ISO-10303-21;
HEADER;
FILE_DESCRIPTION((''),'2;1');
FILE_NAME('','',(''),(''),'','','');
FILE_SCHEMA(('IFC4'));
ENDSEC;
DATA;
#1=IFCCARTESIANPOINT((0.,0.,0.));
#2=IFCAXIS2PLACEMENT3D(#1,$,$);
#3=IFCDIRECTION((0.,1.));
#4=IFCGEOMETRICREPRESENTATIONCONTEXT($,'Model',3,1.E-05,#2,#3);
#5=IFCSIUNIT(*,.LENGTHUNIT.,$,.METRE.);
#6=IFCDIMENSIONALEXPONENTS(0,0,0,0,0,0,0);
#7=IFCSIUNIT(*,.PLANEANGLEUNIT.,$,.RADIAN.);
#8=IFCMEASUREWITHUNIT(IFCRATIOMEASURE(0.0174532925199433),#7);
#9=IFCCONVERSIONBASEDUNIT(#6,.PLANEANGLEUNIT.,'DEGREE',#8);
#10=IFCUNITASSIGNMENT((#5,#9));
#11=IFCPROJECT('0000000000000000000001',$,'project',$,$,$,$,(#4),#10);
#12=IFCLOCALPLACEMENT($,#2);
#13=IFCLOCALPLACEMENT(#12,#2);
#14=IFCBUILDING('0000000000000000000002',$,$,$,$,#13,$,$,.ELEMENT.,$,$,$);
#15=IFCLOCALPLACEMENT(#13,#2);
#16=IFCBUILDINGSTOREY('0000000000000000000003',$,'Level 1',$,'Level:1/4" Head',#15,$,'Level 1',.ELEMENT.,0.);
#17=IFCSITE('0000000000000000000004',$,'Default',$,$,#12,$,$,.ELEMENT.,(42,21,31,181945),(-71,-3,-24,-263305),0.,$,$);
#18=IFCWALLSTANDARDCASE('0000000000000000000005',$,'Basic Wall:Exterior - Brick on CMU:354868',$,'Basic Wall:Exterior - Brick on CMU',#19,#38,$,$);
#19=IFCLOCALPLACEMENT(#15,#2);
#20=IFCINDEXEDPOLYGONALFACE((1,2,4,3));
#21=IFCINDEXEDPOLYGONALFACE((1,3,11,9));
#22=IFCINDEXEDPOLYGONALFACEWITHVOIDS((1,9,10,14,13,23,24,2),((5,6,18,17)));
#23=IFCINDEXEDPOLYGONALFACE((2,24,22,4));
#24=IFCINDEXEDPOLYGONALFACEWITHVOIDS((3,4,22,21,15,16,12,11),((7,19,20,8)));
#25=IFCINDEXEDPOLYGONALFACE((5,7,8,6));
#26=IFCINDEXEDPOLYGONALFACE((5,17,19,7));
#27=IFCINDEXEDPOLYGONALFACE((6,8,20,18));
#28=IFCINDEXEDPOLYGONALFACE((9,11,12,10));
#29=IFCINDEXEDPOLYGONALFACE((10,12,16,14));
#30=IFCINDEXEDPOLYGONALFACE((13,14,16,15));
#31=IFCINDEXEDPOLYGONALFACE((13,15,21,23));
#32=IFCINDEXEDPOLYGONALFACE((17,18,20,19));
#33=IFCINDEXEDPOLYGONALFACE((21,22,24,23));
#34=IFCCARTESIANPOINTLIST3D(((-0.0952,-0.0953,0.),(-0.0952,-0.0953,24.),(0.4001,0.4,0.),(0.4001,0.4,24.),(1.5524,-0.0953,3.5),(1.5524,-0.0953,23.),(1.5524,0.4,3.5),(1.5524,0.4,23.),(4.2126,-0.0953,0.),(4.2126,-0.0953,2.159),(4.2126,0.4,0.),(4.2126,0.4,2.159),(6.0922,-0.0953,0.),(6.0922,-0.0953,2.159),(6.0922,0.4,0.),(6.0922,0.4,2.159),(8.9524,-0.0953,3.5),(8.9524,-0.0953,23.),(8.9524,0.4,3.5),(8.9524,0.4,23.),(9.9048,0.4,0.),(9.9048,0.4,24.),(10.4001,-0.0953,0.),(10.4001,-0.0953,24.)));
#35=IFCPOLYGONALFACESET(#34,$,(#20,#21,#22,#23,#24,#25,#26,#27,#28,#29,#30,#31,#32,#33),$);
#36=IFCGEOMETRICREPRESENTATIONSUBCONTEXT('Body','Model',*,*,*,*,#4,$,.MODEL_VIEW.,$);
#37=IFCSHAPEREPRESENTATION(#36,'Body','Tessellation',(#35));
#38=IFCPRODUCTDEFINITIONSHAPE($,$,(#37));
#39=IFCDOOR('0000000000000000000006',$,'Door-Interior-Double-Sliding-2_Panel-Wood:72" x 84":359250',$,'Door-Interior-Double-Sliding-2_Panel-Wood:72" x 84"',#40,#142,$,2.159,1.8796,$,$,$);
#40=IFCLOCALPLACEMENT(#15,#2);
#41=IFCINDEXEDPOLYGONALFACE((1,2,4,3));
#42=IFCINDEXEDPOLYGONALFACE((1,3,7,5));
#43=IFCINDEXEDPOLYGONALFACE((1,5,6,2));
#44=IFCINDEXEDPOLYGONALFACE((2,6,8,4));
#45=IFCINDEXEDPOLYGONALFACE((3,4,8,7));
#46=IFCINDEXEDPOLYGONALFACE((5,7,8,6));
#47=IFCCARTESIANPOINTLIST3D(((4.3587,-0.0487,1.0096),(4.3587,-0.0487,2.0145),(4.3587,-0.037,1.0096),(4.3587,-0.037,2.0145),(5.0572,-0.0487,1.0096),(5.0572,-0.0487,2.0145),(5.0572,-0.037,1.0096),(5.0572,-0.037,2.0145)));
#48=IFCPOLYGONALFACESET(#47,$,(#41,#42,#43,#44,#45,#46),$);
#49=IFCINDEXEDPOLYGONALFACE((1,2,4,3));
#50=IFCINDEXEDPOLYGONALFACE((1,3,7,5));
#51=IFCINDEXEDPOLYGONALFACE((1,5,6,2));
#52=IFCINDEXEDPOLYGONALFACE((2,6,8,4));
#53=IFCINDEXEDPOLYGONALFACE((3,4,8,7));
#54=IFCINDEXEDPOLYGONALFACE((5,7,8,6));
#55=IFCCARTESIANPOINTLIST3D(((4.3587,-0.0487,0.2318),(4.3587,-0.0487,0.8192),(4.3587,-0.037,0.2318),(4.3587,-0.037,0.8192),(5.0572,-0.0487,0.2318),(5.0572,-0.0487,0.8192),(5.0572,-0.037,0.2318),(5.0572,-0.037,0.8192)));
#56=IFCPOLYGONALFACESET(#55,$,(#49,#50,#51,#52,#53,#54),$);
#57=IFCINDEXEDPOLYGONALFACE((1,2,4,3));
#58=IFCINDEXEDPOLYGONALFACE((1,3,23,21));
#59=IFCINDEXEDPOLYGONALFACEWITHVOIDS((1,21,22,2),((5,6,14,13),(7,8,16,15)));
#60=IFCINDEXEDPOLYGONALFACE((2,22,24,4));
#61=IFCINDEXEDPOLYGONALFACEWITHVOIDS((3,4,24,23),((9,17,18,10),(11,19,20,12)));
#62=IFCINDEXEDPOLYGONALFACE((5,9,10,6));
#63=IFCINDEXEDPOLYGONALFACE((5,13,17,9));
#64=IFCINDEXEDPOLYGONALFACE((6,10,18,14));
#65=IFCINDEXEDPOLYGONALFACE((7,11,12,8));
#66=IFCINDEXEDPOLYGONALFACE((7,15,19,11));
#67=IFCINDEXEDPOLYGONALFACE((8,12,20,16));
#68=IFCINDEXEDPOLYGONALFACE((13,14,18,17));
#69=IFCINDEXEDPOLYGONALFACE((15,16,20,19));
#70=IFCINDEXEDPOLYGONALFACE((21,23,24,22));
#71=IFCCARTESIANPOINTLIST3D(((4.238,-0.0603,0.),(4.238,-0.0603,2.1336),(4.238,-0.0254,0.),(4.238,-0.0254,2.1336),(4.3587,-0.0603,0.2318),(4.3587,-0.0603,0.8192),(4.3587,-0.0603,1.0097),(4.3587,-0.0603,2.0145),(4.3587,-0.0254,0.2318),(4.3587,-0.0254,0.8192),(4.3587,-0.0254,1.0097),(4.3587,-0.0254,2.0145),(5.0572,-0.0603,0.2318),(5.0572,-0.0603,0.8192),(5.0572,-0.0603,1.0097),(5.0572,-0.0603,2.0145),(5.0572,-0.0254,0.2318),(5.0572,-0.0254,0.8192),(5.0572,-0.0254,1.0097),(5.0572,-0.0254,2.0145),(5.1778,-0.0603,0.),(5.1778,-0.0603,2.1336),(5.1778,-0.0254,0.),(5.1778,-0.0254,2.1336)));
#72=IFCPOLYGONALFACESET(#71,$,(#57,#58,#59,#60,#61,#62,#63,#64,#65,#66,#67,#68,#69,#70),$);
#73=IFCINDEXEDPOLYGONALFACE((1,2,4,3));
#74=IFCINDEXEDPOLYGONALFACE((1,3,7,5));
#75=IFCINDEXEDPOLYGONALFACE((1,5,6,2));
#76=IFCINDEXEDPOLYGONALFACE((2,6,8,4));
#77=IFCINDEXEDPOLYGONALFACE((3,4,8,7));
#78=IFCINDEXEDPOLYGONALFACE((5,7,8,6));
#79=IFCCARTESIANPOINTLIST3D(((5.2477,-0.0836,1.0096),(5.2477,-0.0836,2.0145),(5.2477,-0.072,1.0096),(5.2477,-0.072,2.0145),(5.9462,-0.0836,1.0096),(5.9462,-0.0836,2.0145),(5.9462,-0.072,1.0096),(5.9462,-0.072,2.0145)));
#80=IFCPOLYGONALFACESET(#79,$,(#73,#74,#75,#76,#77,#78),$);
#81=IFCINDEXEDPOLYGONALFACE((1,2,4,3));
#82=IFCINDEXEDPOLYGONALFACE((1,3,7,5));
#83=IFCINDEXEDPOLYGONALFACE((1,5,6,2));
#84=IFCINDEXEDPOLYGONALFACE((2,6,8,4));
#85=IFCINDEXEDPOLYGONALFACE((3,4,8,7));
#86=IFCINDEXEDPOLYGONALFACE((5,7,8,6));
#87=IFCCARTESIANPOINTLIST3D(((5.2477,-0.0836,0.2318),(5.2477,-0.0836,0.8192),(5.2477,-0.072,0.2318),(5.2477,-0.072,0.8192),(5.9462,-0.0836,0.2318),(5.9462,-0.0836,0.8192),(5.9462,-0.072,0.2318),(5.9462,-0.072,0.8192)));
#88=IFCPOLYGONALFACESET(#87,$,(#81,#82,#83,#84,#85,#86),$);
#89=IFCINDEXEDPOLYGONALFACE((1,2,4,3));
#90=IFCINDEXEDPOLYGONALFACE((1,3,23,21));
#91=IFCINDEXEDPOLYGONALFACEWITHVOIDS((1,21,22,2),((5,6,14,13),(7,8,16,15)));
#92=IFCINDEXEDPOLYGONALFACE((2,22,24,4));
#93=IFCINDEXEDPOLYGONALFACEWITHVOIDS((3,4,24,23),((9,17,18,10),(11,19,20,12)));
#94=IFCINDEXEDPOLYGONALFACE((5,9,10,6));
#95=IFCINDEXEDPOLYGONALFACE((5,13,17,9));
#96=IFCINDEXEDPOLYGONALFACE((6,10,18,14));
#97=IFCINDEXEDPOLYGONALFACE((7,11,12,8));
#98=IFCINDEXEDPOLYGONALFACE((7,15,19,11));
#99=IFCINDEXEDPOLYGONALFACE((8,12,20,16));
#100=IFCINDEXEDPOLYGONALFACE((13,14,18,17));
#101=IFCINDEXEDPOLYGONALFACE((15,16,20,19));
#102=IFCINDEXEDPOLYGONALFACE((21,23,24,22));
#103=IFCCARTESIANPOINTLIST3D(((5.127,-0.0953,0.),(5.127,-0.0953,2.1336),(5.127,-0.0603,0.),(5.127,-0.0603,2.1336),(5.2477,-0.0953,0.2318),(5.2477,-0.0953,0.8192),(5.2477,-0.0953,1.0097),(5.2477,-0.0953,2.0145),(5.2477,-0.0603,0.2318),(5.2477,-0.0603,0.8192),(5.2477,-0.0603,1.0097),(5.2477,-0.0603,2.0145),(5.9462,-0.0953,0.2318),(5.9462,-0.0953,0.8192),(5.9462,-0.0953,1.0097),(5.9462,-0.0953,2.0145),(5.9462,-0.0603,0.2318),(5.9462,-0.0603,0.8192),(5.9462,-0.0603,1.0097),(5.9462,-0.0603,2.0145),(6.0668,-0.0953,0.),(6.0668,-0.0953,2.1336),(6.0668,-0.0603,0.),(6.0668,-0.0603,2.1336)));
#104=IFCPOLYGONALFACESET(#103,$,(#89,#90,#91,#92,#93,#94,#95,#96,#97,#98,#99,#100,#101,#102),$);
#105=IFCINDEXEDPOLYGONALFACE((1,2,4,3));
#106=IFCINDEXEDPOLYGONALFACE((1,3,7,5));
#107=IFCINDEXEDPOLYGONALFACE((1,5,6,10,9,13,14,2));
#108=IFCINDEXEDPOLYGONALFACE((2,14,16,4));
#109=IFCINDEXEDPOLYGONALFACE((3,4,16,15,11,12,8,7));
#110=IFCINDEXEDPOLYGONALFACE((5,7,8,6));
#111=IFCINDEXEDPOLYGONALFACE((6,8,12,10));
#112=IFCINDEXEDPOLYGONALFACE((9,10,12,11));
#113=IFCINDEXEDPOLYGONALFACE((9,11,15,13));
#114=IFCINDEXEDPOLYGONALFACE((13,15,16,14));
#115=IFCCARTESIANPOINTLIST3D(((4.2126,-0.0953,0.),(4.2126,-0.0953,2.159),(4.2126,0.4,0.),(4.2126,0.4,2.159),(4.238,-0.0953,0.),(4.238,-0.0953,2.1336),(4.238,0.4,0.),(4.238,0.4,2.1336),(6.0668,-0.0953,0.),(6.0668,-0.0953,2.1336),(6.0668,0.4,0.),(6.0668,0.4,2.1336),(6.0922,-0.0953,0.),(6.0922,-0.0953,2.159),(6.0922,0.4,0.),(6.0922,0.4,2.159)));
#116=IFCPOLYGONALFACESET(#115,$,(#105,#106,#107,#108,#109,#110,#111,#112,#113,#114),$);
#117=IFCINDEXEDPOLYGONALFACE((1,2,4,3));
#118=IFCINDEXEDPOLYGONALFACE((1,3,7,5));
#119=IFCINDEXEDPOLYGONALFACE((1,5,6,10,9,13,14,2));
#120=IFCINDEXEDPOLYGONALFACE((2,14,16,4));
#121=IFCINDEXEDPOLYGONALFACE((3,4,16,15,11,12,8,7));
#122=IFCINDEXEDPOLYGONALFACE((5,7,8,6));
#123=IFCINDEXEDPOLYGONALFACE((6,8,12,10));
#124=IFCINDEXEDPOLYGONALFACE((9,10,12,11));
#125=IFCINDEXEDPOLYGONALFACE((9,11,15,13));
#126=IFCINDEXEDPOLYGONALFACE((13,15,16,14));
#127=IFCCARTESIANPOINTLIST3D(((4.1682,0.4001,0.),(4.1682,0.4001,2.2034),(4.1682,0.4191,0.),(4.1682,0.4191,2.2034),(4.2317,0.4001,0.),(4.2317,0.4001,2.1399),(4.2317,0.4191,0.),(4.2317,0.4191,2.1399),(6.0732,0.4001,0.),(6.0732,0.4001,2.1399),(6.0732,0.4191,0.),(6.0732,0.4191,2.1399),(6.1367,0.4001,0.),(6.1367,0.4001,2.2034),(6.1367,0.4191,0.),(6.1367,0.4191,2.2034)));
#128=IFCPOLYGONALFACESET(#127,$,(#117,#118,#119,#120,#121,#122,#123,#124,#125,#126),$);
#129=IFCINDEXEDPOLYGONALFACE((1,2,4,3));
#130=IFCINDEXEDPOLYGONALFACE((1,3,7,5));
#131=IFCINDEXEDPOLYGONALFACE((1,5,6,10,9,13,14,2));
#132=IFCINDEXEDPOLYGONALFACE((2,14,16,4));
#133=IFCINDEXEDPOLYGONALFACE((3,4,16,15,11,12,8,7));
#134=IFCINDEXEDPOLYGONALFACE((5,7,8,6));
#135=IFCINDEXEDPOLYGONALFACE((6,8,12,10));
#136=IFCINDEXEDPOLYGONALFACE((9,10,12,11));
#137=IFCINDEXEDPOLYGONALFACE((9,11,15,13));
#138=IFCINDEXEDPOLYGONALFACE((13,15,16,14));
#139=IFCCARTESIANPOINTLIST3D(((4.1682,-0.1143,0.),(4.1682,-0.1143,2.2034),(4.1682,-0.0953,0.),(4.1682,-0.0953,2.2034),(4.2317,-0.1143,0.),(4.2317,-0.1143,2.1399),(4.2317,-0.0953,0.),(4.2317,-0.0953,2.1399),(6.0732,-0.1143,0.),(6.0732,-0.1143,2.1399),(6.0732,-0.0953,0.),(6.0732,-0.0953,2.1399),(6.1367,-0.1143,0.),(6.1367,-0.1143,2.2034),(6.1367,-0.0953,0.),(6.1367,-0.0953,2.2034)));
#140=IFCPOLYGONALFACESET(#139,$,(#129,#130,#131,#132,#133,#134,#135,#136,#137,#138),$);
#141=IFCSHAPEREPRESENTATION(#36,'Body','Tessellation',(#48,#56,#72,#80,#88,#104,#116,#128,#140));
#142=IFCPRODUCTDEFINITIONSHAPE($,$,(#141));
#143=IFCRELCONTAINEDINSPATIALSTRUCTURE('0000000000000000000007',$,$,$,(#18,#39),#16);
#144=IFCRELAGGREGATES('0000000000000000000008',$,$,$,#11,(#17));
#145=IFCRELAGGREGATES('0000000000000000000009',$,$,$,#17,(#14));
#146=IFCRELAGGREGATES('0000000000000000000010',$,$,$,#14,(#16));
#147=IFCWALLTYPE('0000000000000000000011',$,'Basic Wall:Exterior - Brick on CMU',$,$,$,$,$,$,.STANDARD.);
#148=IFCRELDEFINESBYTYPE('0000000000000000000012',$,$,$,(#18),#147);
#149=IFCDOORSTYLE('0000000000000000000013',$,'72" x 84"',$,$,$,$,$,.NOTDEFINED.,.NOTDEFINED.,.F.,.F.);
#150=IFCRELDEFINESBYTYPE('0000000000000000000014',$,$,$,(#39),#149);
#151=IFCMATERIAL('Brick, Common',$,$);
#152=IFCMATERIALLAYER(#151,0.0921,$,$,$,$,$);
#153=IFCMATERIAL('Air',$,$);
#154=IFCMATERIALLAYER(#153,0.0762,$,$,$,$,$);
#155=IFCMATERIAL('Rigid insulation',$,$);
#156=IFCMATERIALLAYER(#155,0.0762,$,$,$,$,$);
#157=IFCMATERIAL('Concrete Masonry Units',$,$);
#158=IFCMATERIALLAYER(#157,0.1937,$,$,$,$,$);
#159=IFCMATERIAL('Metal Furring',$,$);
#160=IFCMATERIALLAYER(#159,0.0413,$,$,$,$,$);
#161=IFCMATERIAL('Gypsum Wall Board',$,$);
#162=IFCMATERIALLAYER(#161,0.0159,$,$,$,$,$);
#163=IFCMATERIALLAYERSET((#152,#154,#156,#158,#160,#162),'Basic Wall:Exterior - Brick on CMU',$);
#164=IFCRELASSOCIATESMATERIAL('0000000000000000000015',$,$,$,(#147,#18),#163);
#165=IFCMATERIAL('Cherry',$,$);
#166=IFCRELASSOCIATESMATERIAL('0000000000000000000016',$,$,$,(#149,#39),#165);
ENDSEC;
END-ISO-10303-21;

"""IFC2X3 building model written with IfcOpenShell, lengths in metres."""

from ifc_helpers import new_model, entity, si_unit, converted_unit, direction, frame, frame_2d, origin, origin_2d_with_axis, place, context, subcontext, project, spatial, polyline, rectangle, outline, extrude, source, transform, mapped, material, layer, layer_set, layer_usage, type_object, type_shapes, element, fill, save


model = new_model("IFC2X3")

# Units and contexts
model_context = context("Model", 3, precision=1e-05, world=origin(), true_north=direction((0.0, 1.0)))
body_context = subcontext(model_context, "Body", "Model", "MODEL_VIEW")
ifc_project = project(units=[si_unit("LENGTHUNIT", "METRE"), converted_unit("PLANEANGLEUNIT", "DEGREE", entity("IfcRatioMeasure", 0.0174532925199433), si_unit("PLANEANGLEUNIT", "RADIAN"), dimensions=[0, 0, 0, 0, 0, 0, 0])], contexts=[model_context])

# Site, building, storey
site_placement = place(None, origin())
site = spatial("IfcSite", under=ifc_project, at=site_placement, Name="Default", CompositionType="ELEMENT", RefLatitude=(42, 21, 31, 181945), RefLongitude=(-71, -3, -24, -263305), RefElevation=0.0)
building_placement = place(site_placement, origin())
building = spatial("IfcBuilding", under=site, at=building_placement, CompositionType="ELEMENT")
storey_placement = place(building_placement, origin())
storey = spatial("IfcBuildingStorey", under=building, at=storey_placement, Name="Level 1", ObjectType="Level:1/4\" Head", LongName="Level 1", CompositionType="ELEMENT", Elevation=0.0)

# Wall, openings, door
ifc_material_1 = material(Name="Brick, Common")
ifc_layer_1 = layer(ifc_material_1, 0.0921)
ifc_material_2 = material(Name="Air")
ifc_layer_2 = layer(ifc_material_2, 0.0762)
ifc_material_3 = material(Name="Rigid insulation")
ifc_layer_3 = layer(ifc_material_3, 0.0762)
ifc_material_4 = material(Name="Concrete Masonry Units")
ifc_layer_4 = layer(ifc_material_4, 0.1937)
ifc_material_5 = material(Name="Metal Furring")
ifc_layer_5 = layer(ifc_material_5, 0.0413)
ifc_material_6 = material(Name="Gypsum Wall Board")
ifc_layer_6 = layer(ifc_material_6, 0.0159)
ifc_layer_set_1 = layer_set([ifc_layer_1, ifc_layer_2, ifc_layer_3, ifc_layer_4, ifc_layer_5, ifc_layer_6], Name="Basic Wall:Exterior - Brick on CMU")
ifc_layer_usage_1 = layer_usage(ifc_layer_set_1, "AXIS2", "POSITIVE", -0.2477)
wall_type = type_object("IfcWallType", Name="Basic Wall:Exterior - Brick on CMU", PredefinedType="STANDARD", material=ifc_layer_set_1)
wall_placement = place(storey_placement, frame((-0.0952, 0.1524, 0.0)))
wall = element("IfcWallStandardCase", 1, at=wall_placement, inside=storey, type_object=wall_type, material=ifc_layer_usage_1, Name="Basic Wall:Exterior - Brick on CMU:354868", ObjectType="Basic Wall:Exterior - Brick on CMU", context=body_context, shape_type="SweptSolid", body=[
    extrude(outline(polyline([(0.0, -0.2477), (10.4953, -0.2477), (10.0, 0.2477), (0.4953, 0.2477), (0.0, -0.2477)])), origin(), (0.0, 0.0, 1.0), 24.0),
])
opening_1_placement = place(wall_placement, frame((1.6477, -0.4001, 3.5)))
element("IfcOpeningElement", 2, at=opening_1_placement, cuts=wall, ObjectType="Opening", context=body_context, shape_type="SweptSolid", body=[
    extrude(rectangle(XDim=19.5, YDim=7.4, at=frame_2d((0.0, 0.0), x_axis=(1.0, 0.0))), frame((3.7, 0.0, 9.75), z_axis=(0.0, 1.0, 0.0), x_axis=(0.0, 0.0, 1.0)), (0.0, 0.0, 1.0), 0.8001),
])
opening_2_placement = place(wall_placement, frame((6.1875, 0.2476, 0.0)))
opening_2 = element("IfcOpeningElement", 3, at=opening_2_placement, cuts=wall, ObjectType="Opening", context=body_context, shape_type="SweptSolid", body=[
    extrude(rectangle(XDim=2.159, YDim=1.8796, at=frame_2d((1.0795, 0.9398), x_axis=(1.0, 0.0))), frame((0.0, 0.0, 0.0), z_axis=(0.0, -1.0, 0.0), x_axis=(0.0, 0.0, 1.0)), (0.0, 0.0, 1.0), 0.4953),
])
ifc_material_7 = material(Name="Cherry")
door_style = type_object("IfcDoorStyle", Name="72\" x 84\"", ConstructionType="NOTDEFINED", OperationType="NOTDEFINED", ParameterTakesPrecedence=False, Sizeable=False, material=ifc_material_7)
shared_shape_1 = source(origin(), body_context, "Body", "SweptSolid", [
    extrude(rectangle(XDim=0.0116, YDim=0.6985, at=frame_2d((0.0, 0.0), x_axis=(1.0, 0.0))), frame((1.3843, 0.4429, 1.0096), z_axis=(0.0, 0.0, 1.0), x_axis=(0.0, 1.0, 0.0)), (0.0, 0.0, 1.0), 1.0049),
    extrude(rectangle(XDim=0.0116, YDim=0.6985, at=frame_2d((0.0, 0.0), x_axis=(1.0, 0.0))), frame((1.3843, 0.4429, 0.2318), z_axis=(0.0, 0.0, 1.0), x_axis=(0.0, 1.0, 0.0)), (0.0, 0.0, 1.0), 0.5874),
    extrude(outline(polyline([(-0.4699, -1.0668), (0.4699, -1.0668), (0.4699, 1.0668), (-0.4699, 1.0668), (-0.4699, -1.0668)]), holes=[polyline([(-0.3492, -0.9477), (-0.3492, 0.0571), (0.3492, 0.0571), (0.3492, -0.9477), (-0.3492, -0.9477)]), polyline([(-0.3492, 0.2476), (-0.3492, 0.835), (0.3492, 0.835), (0.3492, 0.2476), (-0.3492, 0.2476)])]), frame((1.3843, 0.4255, 1.0668), z_axis=(0.0, 1.0, 0.0), x_axis=(1.0, 0.0, 0.0)), (0.0, 0.0, 1.0), 0.0349),
    extrude(rectangle(XDim=0.0116, YDim=0.6985, at=origin_2d_with_axis()), frame((0.4953, 0.4778, 1.0096), z_axis=(0.0, 0.0, 1.0), x_axis=(0.0, 1.0, 0.0)), (0.0, 0.0, 1.0), 1.0049),
    extrude(rectangle(XDim=0.0116, YDim=0.6985, at=origin_2d_with_axis()), frame((0.4953, 0.4778, 0.2318), z_axis=(0.0, 0.0, 1.0), x_axis=(0.0, 1.0, 0.0)), (0.0, 0.0, 1.0), 0.5874),
    extrude(outline(polyline([(-0.4699, -1.0668), (0.4699, -1.0668), (0.4699, 1.0668), (-0.4699, 1.0668), (-0.4699, -1.0668)]), holes=[polyline([(-0.3493, -0.9477), (-0.3493, 0.0571), (0.3493, 0.0571), (0.3493, -0.9477), (-0.3493, -0.9477)]), polyline([(-0.3493, 0.2476), (-0.3493, 0.835), (0.3493, 0.835), (0.3493, 0.2476), (-0.3493, 0.2476)])]), frame((0.4953, 0.4604, 1.0668), z_axis=(0.0, 1.0, 0.0), x_axis=(1.0, 0.0, 0.0)), (0.0, 0.0, 1.0), 0.0349),
    extrude(outline(polyline([(-1.0732, -0.9144), (-1.0732, -0.9398), (1.0858, -0.9398), (1.0858, 0.9398), (-1.0732, 0.9398), (-1.0732, 0.9144), (1.0604, 0.9144), (1.0604, -0.9144), (-1.0732, -0.9144)])), frame((0.9398, 0.0, 1.0732), z_axis=(0.0, -1.0, 0.0), x_axis=(0.0, 0.0, 1.0)), (0.0, 0.0, -1.0), 0.4953),
    extrude(outline(polyline([(-1.0858, -0.9207), (-1.0858, -0.9842), (1.1176, -0.9842), (1.1176, 0.9842), (-1.0858, 0.9842), (-1.0858, 0.9207), (1.0541, 0.9207), (1.0541, -0.9207), (-1.0858, -0.9207)])), frame((0.9398, -0.0191, 1.0858), z_axis=(0.0, -1.0, 0.0), x_axis=(0.0, 0.0, 1.0)), (0.0, 0.0, -1.0), 0.0191),
    extrude(outline(polyline([(-1.0858, -0.9207), (-1.0858, -0.9842), (1.1176, -0.9842), (1.1176, 0.9842), (-1.0858, 0.9842), (-1.0858, 0.9207), (1.0541, 0.9207), (1.0541, -0.9207), (-1.0858, -0.9207)])), frame((0.9398, 0.4953, 1.0858), z_axis=(0.0, -1.0, 0.0), x_axis=(0.0, 0.0, 1.0)), (0.0, 0.0, -1.0), 0.0191),
])
type_shapes(door_style, [shared_shape_1])
door_placement = place(opening_2_placement, frame((0.0, 0.0, 0.0), z_axis=(0.0, 0.0, 1.0), x_axis=(-1.0, 0.0, 0.0)))
door = element("IfcDoor", 4, at=door_placement, inside=storey, type_object=door_style, material=ifc_material_7, Name="Door-Interior-Double-Sliding-2_Panel-Wood:72\" x 84\":359250", ObjectType="Door-Interior-Double-Sliding-2_Panel-Wood:72\" x 84\"", OverallHeight=2.159, OverallWidth=1.8796, context=body_context, shape_type="MappedRepresentation", body=[
    mapped(shared_shape_1, transform((0.0, 0.0, 0.0), scale=1.0)),
])
fill(opening_2, door)

save(model, "model.ifc")
